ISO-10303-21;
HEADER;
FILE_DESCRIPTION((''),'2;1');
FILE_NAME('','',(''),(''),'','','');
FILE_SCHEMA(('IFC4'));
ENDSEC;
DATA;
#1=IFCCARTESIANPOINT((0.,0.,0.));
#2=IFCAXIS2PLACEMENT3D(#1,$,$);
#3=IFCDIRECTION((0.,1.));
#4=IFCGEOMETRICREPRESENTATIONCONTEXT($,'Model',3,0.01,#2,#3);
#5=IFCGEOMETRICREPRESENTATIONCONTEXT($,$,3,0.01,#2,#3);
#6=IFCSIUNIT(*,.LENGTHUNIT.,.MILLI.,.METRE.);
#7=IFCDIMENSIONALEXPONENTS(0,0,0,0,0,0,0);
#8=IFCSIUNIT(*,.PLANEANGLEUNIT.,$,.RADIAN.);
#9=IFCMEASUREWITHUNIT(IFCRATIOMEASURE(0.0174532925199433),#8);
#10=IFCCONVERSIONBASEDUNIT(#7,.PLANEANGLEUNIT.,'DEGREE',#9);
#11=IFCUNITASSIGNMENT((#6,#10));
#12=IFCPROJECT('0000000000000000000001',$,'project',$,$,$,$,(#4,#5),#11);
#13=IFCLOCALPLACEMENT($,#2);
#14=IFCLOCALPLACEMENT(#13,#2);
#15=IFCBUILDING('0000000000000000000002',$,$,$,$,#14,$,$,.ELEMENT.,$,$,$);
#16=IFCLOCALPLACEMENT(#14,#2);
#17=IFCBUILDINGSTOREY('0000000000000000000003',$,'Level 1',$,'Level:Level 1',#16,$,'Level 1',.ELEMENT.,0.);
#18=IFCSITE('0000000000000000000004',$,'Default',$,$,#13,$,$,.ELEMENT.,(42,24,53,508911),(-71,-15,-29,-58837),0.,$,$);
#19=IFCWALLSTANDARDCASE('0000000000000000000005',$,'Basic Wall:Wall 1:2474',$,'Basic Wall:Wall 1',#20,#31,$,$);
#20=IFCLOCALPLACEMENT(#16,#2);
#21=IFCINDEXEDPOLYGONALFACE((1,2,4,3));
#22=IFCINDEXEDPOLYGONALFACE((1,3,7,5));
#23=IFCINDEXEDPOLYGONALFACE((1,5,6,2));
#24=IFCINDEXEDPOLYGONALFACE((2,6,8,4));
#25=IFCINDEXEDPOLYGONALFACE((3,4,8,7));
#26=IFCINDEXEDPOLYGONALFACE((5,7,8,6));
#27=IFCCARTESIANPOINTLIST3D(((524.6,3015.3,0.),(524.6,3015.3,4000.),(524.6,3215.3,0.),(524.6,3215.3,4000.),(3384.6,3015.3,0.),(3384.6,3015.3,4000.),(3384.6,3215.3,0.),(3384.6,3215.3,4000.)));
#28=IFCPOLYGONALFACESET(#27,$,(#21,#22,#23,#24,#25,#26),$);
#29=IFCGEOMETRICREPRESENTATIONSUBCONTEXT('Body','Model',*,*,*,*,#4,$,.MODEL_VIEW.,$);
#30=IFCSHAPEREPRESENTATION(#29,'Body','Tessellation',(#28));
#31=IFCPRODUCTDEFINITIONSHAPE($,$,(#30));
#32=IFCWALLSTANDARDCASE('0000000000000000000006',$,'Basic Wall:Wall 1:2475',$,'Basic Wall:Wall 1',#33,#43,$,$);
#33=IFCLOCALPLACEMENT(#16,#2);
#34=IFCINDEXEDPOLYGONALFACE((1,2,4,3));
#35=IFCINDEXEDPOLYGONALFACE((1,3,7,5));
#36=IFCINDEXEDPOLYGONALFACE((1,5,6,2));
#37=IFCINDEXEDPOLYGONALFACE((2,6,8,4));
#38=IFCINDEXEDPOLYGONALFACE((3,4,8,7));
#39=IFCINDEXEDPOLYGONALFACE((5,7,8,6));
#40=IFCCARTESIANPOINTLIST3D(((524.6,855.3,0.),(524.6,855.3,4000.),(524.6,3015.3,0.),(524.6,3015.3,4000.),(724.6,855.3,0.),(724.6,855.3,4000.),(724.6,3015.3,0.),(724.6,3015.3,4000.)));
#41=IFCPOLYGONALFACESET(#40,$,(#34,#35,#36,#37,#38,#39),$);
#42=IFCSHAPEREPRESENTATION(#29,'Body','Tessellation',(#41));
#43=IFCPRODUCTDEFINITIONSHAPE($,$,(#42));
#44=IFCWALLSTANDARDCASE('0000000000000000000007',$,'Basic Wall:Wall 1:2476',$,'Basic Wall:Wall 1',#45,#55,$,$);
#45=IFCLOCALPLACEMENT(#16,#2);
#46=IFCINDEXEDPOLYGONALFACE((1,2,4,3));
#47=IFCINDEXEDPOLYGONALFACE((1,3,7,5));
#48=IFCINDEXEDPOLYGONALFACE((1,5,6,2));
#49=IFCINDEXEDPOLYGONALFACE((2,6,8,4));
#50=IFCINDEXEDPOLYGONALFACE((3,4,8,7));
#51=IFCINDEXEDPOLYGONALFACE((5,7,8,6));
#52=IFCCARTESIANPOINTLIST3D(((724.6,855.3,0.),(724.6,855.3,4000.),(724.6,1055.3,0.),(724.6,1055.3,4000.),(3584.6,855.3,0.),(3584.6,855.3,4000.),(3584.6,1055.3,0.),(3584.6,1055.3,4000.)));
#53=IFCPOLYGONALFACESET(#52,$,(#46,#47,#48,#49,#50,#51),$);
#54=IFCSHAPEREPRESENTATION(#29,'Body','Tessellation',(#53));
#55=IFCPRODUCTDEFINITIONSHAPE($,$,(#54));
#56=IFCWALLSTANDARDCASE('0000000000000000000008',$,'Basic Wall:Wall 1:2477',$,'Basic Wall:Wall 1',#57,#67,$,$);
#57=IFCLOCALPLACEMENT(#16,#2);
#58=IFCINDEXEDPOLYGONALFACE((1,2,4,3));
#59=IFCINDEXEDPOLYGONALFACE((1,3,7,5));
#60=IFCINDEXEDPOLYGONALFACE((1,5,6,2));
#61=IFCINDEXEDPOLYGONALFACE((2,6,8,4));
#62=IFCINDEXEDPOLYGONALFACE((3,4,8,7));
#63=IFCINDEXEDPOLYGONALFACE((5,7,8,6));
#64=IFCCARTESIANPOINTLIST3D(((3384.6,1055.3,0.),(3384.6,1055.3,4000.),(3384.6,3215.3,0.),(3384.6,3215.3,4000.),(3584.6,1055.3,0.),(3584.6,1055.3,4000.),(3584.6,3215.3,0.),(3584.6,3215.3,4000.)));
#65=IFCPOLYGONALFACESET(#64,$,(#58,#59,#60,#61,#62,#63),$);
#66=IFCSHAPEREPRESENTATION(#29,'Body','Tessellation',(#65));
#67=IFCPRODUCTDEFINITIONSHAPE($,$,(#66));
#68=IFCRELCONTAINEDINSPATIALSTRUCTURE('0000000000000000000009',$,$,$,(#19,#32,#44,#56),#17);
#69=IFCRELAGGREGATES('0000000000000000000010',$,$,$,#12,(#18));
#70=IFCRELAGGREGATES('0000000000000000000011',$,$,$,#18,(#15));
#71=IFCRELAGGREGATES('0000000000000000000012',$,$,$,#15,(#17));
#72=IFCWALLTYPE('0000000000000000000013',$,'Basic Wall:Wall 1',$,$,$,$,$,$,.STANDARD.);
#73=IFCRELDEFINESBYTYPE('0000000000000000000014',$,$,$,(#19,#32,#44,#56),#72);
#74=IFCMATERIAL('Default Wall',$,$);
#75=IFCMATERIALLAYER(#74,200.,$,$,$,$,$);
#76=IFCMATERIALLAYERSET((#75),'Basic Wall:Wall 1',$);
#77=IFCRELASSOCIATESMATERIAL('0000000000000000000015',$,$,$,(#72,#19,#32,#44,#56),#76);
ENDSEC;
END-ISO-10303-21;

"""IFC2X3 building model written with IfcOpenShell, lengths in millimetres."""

from ifc_helpers import new_model, entity, si_unit, converted_unit, direction, frame, frame_2d, origin, place, context, subcontext, project, spatial, rectangle, extrude, material, layer, layer_set, layer_usage, type_object, element, save


model = new_model("IFC2X3")

# Units and contexts
model_context = context("Model", 3, precision=0.01, world=origin(), true_north=direction((0.0, 1.0)))
context_of_model = context(None, 3, precision=0.01, world=origin(), true_north=direction((0.0, 1.0)))
body_context = subcontext(model_context, "Body", "Model", "MODEL_VIEW")
ifc_project = project(units=[si_unit("LENGTHUNIT", "METRE", prefix="MILLI"), converted_unit("PLANEANGLEUNIT", "DEGREE", entity("IfcRatioMeasure", 0.0174532925199433), si_unit("PLANEANGLEUNIT", "RADIAN"), dimensions=[0, 0, 0, 0, 0, 0, 0])], contexts=[model_context, context_of_model])

# Site, building, storey
site_placement = place(None, origin())
site = spatial("IfcSite", under=ifc_project, at=site_placement, Name="Default", CompositionType="ELEMENT", RefLatitude=(42, 24, 53, 508911), RefLongitude=(-71, -15, -29, -58837), RefElevation=0.0)
building_placement = place(site_placement, origin())
building = spatial("IfcBuilding", under=site, at=building_placement, CompositionType="ELEMENT")
storey_placement = place(building_placement, origin())
storey = spatial("IfcBuildingStorey", under=building, at=storey_placement, Name="Level 1", ObjectType="Level:Level 1", LongName="Level 1", CompositionType="ELEMENT", Elevation=0.0)

# Walls
ifc_material = material(Name="Default Wall")
ifc_layer = layer(ifc_material, 200.0)
ifc_layer_set = layer_set([ifc_layer], Name="Basic Wall:Wall 1")
ifc_layer_usage_1 = layer_usage(ifc_layer_set, "AXIS2", "NEGATIVE", 100.0)
wall_type = type_object("IfcWallType", Name="Basic Wall:Wall 1", PredefinedType="STANDARD", material=ifc_layer_set)
wall_1_placement = place(storey_placement, frame((524.6, 3115.3, 0.0)))
element("IfcWallStandardCase", 1, at=wall_1_placement, inside=storey, type_object=wall_type, material=ifc_layer_usage_1, Name="Basic Wall:Wall 1:2474", ObjectType="Basic Wall:Wall 1", context=body_context, shape_type="SweptSolid", body=[
    extrude(rectangle(XDim=2860.0, YDim=200.0, at=frame_2d((1430.0, 0.0), x_axis=(-1.0, 0.0))), origin(), (0.0, 0.0, 1.0), 4000.0),
])
ifc_layer_usage_2 = layer_usage(ifc_layer_set, "AXIS2", "NEGATIVE", 100.0)
wall_2_placement = place(storey_placement, frame((624.6, 855.3, 0.0), z_axis=(0.0, 0.0, 1.0), x_axis=(0.0, 1.0, 0.0)))
element("IfcWallStandardCase", 2, at=wall_2_placement, inside=storey, type_object=wall_type, material=ifc_layer_usage_2, Name="Basic Wall:Wall 1:2475", ObjectType="Basic Wall:Wall 1", context=body_context, shape_type="SweptSolid", body=[
    extrude(rectangle(XDim=2160.0, YDim=200.0, at=frame_2d((1080.0, 0.0), x_axis=(-1.0, 0.0))), origin(), (0.0, 0.0, 1.0), 4000.0),
])
ifc_layer_usage_3 = layer_usage(ifc_layer_set, "AXIS2", "NEGATIVE", 100.0)
wall_3_placement = place(storey_placement, frame((3584.6, 955.3, 0.0), z_axis=(0.0, 0.0, 1.0), x_axis=(-1.0, 0.0, 0.0)))
element("IfcWallStandardCase", 3, at=wall_3_placement, inside=storey, type_object=wall_type, material=ifc_layer_usage_3, Name="Basic Wall:Wall 1:2476", ObjectType="Basic Wall:Wall 1", context=body_context, shape_type="SweptSolid", body=[
    extrude(rectangle(XDim=2860.0, YDim=200.0, at=frame_2d((1430.0, 0.0), x_axis=(-1.0, 0.0))), origin(), (0.0, 0.0, 1.0), 4000.0),
])
ifc_layer_usage_4 = layer_usage(ifc_layer_set, "AXIS2", "NEGATIVE", 100.0)
wall_4_placement = place(storey_placement, frame((3484.6, 3215.3, 0.0), z_axis=(0.0, 0.0, 1.0), x_axis=(0.0, -1.0, 0.0)))
element("IfcWallStandardCase", 4, at=wall_4_placement, inside=storey, type_object=wall_type, material=ifc_layer_usage_4, Name="Basic Wall:Wall 1:2477", ObjectType="Basic Wall:Wall 1", context=body_context, shape_type="SweptSolid", body=[
    extrude(rectangle(XDim=2160.0, YDim=200.0, at=frame_2d((1080.0, 0.0), x_axis=(-1.0, 0.0))), origin(), (0.0, 0.0, 1.0), 4000.0),
])

save(model, "model.ifc")
